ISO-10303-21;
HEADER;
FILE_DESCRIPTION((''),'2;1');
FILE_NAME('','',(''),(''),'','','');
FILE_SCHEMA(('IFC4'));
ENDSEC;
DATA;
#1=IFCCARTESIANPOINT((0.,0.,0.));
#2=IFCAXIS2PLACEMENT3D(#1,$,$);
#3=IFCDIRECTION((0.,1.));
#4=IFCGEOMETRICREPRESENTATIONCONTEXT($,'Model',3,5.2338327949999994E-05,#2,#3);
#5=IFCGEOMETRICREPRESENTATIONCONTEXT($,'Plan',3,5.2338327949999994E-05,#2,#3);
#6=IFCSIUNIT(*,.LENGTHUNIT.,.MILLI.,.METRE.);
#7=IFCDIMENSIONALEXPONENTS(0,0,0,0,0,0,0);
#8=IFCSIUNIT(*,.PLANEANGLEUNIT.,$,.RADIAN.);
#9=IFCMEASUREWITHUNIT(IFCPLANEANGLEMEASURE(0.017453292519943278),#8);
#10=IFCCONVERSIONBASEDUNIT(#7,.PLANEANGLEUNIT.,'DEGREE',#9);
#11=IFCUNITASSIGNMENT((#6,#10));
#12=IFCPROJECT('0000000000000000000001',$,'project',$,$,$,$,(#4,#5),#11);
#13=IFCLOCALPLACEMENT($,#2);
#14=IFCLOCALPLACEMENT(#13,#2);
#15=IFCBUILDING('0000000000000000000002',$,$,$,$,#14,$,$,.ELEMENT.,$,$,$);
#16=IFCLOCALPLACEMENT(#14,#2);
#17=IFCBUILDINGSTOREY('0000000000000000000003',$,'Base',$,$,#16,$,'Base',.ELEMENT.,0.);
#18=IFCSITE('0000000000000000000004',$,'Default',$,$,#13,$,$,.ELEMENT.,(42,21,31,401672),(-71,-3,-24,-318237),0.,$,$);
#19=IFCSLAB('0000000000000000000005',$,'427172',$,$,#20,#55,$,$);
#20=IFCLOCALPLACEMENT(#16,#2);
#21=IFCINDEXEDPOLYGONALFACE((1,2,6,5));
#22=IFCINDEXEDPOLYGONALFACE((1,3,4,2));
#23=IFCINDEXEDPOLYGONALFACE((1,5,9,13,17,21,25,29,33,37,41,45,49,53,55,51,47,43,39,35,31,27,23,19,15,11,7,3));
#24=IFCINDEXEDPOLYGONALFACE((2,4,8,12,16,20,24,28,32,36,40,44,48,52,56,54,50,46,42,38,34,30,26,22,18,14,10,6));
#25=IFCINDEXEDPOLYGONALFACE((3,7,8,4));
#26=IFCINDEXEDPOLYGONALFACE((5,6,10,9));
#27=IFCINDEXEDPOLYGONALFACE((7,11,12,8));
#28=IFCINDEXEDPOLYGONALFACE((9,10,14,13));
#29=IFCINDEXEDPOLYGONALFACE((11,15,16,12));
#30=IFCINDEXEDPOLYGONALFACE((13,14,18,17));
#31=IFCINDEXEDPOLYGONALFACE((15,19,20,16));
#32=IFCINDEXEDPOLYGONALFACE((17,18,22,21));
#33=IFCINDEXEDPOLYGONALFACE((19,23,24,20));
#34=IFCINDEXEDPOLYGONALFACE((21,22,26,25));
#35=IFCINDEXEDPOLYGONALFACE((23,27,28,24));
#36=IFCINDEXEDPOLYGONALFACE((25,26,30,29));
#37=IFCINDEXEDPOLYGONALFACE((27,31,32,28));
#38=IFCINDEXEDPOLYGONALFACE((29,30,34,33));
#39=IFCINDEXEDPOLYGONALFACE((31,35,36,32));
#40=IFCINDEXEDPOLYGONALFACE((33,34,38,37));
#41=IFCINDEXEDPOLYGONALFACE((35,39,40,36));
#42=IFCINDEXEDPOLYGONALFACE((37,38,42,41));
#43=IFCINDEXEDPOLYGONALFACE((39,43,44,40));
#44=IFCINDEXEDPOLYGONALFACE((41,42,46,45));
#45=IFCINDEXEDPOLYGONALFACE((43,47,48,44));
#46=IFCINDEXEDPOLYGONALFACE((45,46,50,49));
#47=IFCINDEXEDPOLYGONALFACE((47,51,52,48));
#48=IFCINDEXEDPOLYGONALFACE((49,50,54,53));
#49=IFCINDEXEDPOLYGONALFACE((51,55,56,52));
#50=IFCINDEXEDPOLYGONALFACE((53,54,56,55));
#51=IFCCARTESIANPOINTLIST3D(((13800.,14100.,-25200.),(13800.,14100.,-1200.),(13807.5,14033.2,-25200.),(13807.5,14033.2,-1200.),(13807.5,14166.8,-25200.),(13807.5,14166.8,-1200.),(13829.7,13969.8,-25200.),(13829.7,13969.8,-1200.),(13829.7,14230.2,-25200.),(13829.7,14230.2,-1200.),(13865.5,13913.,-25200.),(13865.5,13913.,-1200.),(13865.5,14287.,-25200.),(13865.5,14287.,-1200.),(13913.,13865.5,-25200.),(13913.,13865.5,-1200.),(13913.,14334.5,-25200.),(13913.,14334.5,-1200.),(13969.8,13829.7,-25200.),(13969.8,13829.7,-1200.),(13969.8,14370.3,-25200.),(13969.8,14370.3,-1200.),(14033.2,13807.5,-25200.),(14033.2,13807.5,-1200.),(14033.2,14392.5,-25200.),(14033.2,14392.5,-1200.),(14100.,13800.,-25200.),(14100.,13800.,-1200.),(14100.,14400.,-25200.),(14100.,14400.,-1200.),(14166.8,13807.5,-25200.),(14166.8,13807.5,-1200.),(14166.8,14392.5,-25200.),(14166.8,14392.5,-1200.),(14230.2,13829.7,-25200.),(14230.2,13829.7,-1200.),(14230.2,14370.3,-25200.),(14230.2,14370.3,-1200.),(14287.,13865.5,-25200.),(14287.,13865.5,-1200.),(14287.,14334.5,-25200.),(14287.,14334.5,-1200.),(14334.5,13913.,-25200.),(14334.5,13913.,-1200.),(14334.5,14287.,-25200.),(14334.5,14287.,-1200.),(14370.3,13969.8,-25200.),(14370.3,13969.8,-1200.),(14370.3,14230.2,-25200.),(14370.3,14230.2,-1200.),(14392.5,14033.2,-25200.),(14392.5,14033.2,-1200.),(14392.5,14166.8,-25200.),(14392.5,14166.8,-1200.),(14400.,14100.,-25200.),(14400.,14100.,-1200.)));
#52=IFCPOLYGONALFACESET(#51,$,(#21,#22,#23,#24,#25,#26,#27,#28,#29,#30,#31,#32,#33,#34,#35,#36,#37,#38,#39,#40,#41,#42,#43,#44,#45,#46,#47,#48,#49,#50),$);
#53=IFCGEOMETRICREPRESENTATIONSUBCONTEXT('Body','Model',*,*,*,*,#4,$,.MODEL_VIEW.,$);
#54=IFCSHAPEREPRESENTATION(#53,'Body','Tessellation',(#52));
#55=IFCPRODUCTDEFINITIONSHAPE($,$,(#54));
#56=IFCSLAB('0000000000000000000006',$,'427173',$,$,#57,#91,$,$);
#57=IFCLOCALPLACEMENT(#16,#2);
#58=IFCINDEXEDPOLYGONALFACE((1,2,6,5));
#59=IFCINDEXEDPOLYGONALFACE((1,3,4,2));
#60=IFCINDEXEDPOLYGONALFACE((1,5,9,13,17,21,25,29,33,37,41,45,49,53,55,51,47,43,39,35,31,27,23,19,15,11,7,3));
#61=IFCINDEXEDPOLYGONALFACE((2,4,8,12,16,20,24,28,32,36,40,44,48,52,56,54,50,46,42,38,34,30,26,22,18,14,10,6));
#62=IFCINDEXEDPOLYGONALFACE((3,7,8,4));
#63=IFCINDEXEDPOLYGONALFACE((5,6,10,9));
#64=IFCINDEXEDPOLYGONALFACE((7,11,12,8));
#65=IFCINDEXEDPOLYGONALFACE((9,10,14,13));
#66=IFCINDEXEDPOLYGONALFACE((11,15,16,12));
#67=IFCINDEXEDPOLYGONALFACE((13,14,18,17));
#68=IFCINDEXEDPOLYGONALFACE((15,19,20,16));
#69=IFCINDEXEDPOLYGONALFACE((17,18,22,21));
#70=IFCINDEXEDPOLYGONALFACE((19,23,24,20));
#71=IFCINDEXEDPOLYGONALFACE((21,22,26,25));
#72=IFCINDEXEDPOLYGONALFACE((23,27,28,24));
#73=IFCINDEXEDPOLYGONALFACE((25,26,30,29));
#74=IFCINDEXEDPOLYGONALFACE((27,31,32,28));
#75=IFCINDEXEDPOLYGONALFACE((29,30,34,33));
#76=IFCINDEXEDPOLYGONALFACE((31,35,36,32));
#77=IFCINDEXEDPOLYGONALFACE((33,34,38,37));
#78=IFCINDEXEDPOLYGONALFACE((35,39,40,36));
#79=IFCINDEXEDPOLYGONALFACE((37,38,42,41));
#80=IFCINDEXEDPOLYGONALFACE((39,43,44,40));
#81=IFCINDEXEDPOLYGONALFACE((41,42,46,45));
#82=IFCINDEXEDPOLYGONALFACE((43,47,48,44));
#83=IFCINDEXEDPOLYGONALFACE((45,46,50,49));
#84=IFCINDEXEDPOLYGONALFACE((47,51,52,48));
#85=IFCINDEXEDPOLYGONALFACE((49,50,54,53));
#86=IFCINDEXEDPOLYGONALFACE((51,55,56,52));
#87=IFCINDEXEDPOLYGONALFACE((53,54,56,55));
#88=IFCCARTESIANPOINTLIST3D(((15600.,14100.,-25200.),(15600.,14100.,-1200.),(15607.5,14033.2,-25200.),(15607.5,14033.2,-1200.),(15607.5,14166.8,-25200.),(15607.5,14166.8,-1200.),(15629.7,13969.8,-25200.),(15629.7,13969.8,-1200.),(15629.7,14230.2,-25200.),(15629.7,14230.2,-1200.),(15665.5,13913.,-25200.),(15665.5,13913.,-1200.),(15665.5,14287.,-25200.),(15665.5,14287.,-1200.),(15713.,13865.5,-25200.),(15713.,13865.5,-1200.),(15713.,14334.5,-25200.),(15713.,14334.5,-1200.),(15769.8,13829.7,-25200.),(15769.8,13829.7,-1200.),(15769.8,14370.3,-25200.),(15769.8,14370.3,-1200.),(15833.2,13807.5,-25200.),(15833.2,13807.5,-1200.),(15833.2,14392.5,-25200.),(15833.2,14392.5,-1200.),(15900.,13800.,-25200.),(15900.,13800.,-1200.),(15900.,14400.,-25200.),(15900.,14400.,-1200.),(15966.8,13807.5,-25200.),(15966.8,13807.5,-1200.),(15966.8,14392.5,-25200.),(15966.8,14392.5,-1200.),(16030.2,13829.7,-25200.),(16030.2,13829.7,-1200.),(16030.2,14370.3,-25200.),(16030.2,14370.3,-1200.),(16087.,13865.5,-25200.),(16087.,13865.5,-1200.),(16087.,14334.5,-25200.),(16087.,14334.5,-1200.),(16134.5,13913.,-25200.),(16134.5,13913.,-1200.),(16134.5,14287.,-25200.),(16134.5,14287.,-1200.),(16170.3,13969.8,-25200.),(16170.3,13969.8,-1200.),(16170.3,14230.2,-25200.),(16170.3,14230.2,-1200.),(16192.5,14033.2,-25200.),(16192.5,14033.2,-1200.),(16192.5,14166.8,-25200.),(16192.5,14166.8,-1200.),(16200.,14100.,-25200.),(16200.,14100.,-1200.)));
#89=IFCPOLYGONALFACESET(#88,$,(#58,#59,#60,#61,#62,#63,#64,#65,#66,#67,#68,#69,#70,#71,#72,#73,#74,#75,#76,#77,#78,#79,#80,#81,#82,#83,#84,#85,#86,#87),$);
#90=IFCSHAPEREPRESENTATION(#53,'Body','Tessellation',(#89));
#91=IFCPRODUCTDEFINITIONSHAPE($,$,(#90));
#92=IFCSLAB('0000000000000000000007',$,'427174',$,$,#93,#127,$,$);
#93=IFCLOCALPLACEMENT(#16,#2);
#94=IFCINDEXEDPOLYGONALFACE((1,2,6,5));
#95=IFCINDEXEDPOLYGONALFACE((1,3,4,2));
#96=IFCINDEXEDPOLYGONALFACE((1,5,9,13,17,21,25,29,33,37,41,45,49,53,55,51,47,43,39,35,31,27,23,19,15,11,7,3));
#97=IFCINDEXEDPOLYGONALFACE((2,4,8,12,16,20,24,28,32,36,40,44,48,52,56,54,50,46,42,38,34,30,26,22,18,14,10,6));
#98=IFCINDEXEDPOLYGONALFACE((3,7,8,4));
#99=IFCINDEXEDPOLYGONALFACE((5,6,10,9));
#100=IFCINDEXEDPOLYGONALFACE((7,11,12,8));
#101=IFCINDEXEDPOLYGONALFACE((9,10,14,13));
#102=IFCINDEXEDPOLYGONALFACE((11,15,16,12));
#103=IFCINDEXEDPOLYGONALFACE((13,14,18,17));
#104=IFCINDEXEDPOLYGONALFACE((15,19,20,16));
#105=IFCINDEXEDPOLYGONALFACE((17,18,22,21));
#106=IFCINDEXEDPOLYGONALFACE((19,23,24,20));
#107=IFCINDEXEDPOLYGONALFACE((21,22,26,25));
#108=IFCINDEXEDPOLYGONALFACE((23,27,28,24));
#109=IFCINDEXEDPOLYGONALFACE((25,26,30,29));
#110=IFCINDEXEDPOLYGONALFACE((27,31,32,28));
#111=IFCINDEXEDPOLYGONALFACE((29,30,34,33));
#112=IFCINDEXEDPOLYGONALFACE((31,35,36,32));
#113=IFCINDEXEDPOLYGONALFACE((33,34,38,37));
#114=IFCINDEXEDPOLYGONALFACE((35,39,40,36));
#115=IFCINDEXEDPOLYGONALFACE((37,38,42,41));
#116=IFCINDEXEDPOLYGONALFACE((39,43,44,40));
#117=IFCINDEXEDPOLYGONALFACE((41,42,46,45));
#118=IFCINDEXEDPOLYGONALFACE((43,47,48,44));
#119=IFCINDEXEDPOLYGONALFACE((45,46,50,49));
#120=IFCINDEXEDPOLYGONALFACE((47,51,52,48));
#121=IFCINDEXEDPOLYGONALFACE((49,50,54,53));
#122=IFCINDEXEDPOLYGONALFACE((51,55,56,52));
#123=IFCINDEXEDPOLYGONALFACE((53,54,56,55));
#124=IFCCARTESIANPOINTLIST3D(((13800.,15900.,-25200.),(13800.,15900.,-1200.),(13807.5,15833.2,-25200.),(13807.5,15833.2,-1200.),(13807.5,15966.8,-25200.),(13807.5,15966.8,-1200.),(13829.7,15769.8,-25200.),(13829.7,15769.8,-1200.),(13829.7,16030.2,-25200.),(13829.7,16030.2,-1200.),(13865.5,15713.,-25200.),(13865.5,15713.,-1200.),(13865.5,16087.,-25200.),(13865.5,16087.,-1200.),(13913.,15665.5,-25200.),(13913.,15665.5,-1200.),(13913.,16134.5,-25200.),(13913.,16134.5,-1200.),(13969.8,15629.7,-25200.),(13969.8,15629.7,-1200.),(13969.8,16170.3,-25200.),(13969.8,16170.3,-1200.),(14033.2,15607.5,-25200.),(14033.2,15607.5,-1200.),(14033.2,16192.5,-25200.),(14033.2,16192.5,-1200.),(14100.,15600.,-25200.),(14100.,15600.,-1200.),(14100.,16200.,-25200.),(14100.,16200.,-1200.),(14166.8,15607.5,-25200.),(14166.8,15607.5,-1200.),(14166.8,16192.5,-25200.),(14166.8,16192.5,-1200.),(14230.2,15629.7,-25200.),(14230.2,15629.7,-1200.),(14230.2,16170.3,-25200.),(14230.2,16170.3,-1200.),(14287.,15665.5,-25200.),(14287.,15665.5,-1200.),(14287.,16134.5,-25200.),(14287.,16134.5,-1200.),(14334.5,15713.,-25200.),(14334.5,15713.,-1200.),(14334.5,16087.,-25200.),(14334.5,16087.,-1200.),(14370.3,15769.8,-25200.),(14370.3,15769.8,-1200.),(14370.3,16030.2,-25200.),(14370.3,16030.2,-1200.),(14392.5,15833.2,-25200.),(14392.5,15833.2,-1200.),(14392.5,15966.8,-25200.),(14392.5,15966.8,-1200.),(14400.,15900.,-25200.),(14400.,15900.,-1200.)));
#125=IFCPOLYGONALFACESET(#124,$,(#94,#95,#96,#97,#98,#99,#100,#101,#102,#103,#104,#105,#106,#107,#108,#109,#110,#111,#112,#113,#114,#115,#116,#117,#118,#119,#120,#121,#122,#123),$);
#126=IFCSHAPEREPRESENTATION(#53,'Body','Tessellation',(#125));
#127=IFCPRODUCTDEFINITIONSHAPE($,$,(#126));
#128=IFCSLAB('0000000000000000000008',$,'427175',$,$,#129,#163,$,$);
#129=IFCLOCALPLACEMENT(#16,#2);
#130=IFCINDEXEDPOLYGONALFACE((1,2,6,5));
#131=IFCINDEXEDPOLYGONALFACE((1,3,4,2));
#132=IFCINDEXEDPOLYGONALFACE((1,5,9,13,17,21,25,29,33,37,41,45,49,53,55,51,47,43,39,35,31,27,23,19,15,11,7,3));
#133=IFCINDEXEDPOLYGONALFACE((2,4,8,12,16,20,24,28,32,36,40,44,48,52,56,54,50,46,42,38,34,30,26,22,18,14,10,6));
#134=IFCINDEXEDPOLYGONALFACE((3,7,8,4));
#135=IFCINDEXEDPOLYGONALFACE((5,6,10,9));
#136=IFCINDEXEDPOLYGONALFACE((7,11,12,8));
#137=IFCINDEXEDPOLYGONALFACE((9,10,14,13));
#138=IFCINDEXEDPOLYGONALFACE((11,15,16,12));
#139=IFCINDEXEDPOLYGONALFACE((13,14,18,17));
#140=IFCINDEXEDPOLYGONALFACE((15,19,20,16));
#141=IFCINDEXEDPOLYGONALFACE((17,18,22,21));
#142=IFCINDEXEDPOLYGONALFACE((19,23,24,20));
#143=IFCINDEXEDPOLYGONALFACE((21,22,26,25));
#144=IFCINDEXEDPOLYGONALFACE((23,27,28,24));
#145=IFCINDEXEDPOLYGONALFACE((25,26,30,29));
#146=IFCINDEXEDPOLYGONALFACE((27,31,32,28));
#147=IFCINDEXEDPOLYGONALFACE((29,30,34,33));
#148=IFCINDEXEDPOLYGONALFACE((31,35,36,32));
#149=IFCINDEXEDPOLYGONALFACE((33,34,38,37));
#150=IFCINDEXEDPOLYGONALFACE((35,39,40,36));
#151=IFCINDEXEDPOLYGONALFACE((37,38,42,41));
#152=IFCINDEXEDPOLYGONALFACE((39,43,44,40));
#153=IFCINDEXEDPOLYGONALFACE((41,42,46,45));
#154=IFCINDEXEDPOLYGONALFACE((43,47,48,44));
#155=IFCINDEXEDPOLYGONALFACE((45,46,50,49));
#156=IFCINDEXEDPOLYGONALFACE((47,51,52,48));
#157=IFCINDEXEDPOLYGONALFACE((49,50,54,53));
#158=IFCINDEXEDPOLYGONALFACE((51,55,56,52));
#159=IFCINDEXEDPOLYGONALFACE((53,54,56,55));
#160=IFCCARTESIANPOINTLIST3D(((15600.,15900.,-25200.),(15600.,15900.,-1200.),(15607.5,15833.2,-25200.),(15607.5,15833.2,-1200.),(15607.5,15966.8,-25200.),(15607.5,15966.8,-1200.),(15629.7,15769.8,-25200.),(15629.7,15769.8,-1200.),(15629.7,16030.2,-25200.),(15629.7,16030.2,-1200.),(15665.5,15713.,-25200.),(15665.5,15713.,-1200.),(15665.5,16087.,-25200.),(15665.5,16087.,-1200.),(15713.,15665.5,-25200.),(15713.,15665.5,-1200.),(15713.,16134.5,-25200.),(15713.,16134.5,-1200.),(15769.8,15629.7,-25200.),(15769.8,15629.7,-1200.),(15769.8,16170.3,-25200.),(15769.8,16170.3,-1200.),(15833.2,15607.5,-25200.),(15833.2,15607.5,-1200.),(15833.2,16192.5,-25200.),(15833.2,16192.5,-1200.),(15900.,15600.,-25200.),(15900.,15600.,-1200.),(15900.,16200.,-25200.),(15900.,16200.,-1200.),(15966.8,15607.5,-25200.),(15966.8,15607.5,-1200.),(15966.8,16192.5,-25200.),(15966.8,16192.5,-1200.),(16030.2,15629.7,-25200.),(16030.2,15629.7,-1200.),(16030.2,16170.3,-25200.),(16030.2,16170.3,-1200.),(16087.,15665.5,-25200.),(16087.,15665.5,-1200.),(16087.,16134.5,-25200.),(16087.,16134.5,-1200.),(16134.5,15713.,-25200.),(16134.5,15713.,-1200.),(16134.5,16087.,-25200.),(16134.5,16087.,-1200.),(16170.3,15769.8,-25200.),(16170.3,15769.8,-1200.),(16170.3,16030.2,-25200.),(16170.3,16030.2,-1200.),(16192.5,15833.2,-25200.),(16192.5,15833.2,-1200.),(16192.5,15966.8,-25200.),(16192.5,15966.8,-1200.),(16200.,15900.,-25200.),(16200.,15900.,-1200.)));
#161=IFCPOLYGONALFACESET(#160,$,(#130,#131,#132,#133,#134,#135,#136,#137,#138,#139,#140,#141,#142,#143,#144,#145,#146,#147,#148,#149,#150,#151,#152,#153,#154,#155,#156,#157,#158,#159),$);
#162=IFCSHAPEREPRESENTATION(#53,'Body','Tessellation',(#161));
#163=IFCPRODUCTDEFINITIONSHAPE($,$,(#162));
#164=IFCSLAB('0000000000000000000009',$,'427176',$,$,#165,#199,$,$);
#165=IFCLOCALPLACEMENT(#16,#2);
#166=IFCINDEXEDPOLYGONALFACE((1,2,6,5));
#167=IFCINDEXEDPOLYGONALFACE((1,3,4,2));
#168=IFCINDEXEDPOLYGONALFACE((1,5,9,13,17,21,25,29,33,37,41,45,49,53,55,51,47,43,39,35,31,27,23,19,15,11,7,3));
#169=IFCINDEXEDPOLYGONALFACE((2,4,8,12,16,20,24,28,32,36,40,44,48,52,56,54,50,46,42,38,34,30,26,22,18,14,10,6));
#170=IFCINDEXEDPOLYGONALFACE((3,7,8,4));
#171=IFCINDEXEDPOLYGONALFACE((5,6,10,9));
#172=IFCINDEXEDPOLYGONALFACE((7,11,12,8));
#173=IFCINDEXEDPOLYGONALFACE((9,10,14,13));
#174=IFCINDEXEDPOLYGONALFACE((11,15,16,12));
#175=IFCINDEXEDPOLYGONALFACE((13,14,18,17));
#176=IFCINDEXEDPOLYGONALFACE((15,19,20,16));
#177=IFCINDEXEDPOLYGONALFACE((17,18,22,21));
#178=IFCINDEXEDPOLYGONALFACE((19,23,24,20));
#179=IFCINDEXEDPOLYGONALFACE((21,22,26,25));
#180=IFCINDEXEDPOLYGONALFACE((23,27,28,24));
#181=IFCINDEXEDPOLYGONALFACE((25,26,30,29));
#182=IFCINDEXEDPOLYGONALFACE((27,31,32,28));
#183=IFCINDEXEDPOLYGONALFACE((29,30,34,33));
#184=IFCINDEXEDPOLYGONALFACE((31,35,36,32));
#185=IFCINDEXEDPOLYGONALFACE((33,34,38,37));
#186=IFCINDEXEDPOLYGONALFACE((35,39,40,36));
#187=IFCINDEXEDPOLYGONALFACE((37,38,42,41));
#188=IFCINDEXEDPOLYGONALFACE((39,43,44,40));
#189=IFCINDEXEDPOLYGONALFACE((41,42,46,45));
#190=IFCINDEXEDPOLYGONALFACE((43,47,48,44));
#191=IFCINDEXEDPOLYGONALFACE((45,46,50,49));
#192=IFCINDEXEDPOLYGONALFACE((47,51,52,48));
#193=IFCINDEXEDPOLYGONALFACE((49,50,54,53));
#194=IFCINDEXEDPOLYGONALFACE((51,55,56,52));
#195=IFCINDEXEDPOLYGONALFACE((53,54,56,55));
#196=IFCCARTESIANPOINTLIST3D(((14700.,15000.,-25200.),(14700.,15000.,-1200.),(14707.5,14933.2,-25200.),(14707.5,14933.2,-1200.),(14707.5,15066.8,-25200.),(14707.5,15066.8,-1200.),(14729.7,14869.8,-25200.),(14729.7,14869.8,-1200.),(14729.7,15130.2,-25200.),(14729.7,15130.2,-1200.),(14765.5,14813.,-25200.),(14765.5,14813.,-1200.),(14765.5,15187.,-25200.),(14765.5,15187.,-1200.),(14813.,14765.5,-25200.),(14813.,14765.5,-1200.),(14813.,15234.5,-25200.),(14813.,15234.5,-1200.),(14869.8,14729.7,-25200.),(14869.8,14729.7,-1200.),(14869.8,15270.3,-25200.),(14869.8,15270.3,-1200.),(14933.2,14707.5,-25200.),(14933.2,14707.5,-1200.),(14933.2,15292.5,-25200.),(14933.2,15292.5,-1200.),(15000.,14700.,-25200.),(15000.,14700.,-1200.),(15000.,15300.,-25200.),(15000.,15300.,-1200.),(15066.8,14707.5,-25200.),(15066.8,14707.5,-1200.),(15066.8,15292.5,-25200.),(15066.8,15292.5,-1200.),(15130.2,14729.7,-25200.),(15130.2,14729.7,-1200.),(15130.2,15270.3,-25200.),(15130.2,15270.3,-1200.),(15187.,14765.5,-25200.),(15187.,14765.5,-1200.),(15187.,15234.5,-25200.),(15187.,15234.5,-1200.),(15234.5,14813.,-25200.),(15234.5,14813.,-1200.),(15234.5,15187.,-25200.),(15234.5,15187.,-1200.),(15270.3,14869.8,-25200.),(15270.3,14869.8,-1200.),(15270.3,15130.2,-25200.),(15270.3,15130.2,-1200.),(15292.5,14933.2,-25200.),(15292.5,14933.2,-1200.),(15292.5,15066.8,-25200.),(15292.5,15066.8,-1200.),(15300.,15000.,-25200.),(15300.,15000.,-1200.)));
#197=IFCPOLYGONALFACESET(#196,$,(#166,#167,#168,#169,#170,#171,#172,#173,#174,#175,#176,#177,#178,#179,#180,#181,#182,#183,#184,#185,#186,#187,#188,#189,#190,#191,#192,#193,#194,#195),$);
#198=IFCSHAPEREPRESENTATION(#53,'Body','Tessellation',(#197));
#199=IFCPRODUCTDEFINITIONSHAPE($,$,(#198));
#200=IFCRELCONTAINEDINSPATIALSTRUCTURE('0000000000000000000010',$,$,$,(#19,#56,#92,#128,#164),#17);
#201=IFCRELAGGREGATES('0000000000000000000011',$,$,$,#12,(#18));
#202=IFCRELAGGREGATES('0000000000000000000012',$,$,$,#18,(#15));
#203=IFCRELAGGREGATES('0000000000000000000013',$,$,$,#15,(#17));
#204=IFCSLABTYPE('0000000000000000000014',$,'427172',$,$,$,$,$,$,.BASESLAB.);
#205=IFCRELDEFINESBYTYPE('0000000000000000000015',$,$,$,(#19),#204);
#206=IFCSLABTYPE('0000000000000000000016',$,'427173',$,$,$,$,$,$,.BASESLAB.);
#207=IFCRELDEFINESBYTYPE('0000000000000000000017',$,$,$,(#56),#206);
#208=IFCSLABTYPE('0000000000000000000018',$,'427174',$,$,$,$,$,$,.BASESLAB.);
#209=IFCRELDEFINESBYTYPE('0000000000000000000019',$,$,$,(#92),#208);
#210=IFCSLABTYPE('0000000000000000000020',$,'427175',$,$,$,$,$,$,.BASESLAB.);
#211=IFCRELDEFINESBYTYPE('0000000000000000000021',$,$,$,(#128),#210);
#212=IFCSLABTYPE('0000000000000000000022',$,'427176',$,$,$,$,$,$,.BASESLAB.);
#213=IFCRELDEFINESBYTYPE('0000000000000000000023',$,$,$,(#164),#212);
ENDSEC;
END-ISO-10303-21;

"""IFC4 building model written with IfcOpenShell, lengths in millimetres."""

from ifc_helpers import new_model, entity, si_unit, converted_unit, direction, frame, origin, place, context, subcontext, project, spatial, arc, indexed_curve, outline, extrude, type_object, element, save


model = new_model("IFC4")

# Units and contexts
model_context = context("Model", 3, precision=5.2338327949999994e-05, world=origin(), true_north=direction((0.0, 1.0)))
plan_context = context("Plan", 3, precision=5.2338327949999994e-05, world=origin(), true_north=direction((0.0, 1.0)))
body_context = subcontext(model_context, "Body", "Model", "MODEL_VIEW")
ifc_project = project(units=[si_unit("LENGTHUNIT", "METRE", prefix="MILLI"), converted_unit("PLANEANGLEUNIT", "DEGREE", entity("IfcPlaneAngleMeasure", 0.017453292519943278), si_unit("PLANEANGLEUNIT", "RADIAN"), dimensions=[0, 0, 0, 0, 0, 0, 0])], contexts=[model_context, plan_context])

# Site, building, storey
site_placement = place(None, origin())
site = spatial("IfcSite", under=ifc_project, at=site_placement, Name="Default", CompositionType="ELEMENT", RefLatitude=(42, 21, 31, 401672), RefLongitude=(-71, -3, -24, -318237), RefElevation=0.0)
building_placement = place(site_placement, origin())
building = spatial("IfcBuilding", under=site, at=building_placement, CompositionType="ELEMENT")
storey_placement = place(building_placement, origin())
storey = spatial("IfcBuildingStorey", under=building, at=storey_placement, Name="Base", LongName="Base", CompositionType="ELEMENT", Elevation=0.0)

# Slabs
slab_type_1 = type_object("IfcSlabType", Name="427172", PredefinedType="BASESLAB")
slab_1_placement = place(storey_placement, origin())
element("IfcSlab", 1, at=slab_1_placement, inside=storey, type_object=slab_type_1, Name="427172", context=body_context, shape_type="SweptSolid", body=[
    extrude(outline(indexed_curve([(300.0, 0.0), (0.0, 300.0), (-300.0, 0.0), (0.0, -300.0)], segments=[arc(1, 2, 3), arc(3, 4, 1)], self_intersect=False)), frame((14100.0, 14100.0, -25200.0)), (0.0, 0.0, 1.0), 24000.0),
])
slab_type_2 = type_object("IfcSlabType", Name="427173", PredefinedType="BASESLAB")
slab_2_placement = place(storey_placement, origin())
element("IfcSlab", 2, at=slab_2_placement, inside=storey, type_object=slab_type_2, Name="427173", context=body_context, shape_type="SweptSolid", body=[
    extrude(outline(indexed_curve([(300.0, 0.0), (0.0, 300.0), (-300.0, 0.0), (0.0, -300.0)], segments=[arc(1, 2, 3), arc(3, 4, 1)], self_intersect=False)), frame((15900.0, 14100.0, -25200.0)), (0.0, 0.0, 1.0), 24000.0),
])
slab_type_3 = type_object("IfcSlabType", Name="427174", PredefinedType="BASESLAB")
slab_3_placement = place(storey_placement, origin())
element("IfcSlab", 3, at=slab_3_placement, inside=storey, type_object=slab_type_3, Name="427174", context=body_context, shape_type="SweptSolid", body=[
    extrude(outline(indexed_curve([(300.0, 0.0), (0.0, 300.0), (-300.0, 0.0), (0.0, -300.0)], segments=[arc(1, 2, 3), arc(3, 4, 1)], self_intersect=False)), frame((14100.0, 15900.0, -25200.0)), (0.0, 0.0, 1.0), 24000.0),
])
slab_type_4 = type_object("IfcSlabType", Name="427175", PredefinedType="BASESLAB")
slab_4_placement = place(storey_placement, origin())
element("IfcSlab", 4, at=slab_4_placement, inside=storey, type_object=slab_type_4, Name="427175", context=body_context, shape_type="SweptSolid", body=[
    extrude(outline(indexed_curve([(300.0, 0.0), (0.0, 300.0), (-300.0, 0.0), (0.0, -300.0)], segments=[arc(1, 2, 3), arc(3, 4, 1)], self_intersect=False)), frame((15900.0, 15900.0, -25200.0)), (0.0, 0.0, 1.0), 24000.0),
])
slab_type_5 = type_object("IfcSlabType", Name="427176", PredefinedType="BASESLAB")
slab_5_placement = place(storey_placement, origin())
element("IfcSlab", 5, at=slab_5_placement, inside=storey, type_object=slab_type_5, Name="427176", context=body_context, shape_type="SweptSolid", body=[
    extrude(outline(indexed_curve([(300.0, 0.0), (0.0, 300.0), (-300.0, 0.0), (0.0, -300.0)], segments=[arc(1, 2, 3), arc(3, 4, 1)], self_intersect=False)), frame((15000.0, 15000.0, -25200.0)), (0.0, 0.0, 1.0), 24000.0),
])

save(model, "model.ifc")
